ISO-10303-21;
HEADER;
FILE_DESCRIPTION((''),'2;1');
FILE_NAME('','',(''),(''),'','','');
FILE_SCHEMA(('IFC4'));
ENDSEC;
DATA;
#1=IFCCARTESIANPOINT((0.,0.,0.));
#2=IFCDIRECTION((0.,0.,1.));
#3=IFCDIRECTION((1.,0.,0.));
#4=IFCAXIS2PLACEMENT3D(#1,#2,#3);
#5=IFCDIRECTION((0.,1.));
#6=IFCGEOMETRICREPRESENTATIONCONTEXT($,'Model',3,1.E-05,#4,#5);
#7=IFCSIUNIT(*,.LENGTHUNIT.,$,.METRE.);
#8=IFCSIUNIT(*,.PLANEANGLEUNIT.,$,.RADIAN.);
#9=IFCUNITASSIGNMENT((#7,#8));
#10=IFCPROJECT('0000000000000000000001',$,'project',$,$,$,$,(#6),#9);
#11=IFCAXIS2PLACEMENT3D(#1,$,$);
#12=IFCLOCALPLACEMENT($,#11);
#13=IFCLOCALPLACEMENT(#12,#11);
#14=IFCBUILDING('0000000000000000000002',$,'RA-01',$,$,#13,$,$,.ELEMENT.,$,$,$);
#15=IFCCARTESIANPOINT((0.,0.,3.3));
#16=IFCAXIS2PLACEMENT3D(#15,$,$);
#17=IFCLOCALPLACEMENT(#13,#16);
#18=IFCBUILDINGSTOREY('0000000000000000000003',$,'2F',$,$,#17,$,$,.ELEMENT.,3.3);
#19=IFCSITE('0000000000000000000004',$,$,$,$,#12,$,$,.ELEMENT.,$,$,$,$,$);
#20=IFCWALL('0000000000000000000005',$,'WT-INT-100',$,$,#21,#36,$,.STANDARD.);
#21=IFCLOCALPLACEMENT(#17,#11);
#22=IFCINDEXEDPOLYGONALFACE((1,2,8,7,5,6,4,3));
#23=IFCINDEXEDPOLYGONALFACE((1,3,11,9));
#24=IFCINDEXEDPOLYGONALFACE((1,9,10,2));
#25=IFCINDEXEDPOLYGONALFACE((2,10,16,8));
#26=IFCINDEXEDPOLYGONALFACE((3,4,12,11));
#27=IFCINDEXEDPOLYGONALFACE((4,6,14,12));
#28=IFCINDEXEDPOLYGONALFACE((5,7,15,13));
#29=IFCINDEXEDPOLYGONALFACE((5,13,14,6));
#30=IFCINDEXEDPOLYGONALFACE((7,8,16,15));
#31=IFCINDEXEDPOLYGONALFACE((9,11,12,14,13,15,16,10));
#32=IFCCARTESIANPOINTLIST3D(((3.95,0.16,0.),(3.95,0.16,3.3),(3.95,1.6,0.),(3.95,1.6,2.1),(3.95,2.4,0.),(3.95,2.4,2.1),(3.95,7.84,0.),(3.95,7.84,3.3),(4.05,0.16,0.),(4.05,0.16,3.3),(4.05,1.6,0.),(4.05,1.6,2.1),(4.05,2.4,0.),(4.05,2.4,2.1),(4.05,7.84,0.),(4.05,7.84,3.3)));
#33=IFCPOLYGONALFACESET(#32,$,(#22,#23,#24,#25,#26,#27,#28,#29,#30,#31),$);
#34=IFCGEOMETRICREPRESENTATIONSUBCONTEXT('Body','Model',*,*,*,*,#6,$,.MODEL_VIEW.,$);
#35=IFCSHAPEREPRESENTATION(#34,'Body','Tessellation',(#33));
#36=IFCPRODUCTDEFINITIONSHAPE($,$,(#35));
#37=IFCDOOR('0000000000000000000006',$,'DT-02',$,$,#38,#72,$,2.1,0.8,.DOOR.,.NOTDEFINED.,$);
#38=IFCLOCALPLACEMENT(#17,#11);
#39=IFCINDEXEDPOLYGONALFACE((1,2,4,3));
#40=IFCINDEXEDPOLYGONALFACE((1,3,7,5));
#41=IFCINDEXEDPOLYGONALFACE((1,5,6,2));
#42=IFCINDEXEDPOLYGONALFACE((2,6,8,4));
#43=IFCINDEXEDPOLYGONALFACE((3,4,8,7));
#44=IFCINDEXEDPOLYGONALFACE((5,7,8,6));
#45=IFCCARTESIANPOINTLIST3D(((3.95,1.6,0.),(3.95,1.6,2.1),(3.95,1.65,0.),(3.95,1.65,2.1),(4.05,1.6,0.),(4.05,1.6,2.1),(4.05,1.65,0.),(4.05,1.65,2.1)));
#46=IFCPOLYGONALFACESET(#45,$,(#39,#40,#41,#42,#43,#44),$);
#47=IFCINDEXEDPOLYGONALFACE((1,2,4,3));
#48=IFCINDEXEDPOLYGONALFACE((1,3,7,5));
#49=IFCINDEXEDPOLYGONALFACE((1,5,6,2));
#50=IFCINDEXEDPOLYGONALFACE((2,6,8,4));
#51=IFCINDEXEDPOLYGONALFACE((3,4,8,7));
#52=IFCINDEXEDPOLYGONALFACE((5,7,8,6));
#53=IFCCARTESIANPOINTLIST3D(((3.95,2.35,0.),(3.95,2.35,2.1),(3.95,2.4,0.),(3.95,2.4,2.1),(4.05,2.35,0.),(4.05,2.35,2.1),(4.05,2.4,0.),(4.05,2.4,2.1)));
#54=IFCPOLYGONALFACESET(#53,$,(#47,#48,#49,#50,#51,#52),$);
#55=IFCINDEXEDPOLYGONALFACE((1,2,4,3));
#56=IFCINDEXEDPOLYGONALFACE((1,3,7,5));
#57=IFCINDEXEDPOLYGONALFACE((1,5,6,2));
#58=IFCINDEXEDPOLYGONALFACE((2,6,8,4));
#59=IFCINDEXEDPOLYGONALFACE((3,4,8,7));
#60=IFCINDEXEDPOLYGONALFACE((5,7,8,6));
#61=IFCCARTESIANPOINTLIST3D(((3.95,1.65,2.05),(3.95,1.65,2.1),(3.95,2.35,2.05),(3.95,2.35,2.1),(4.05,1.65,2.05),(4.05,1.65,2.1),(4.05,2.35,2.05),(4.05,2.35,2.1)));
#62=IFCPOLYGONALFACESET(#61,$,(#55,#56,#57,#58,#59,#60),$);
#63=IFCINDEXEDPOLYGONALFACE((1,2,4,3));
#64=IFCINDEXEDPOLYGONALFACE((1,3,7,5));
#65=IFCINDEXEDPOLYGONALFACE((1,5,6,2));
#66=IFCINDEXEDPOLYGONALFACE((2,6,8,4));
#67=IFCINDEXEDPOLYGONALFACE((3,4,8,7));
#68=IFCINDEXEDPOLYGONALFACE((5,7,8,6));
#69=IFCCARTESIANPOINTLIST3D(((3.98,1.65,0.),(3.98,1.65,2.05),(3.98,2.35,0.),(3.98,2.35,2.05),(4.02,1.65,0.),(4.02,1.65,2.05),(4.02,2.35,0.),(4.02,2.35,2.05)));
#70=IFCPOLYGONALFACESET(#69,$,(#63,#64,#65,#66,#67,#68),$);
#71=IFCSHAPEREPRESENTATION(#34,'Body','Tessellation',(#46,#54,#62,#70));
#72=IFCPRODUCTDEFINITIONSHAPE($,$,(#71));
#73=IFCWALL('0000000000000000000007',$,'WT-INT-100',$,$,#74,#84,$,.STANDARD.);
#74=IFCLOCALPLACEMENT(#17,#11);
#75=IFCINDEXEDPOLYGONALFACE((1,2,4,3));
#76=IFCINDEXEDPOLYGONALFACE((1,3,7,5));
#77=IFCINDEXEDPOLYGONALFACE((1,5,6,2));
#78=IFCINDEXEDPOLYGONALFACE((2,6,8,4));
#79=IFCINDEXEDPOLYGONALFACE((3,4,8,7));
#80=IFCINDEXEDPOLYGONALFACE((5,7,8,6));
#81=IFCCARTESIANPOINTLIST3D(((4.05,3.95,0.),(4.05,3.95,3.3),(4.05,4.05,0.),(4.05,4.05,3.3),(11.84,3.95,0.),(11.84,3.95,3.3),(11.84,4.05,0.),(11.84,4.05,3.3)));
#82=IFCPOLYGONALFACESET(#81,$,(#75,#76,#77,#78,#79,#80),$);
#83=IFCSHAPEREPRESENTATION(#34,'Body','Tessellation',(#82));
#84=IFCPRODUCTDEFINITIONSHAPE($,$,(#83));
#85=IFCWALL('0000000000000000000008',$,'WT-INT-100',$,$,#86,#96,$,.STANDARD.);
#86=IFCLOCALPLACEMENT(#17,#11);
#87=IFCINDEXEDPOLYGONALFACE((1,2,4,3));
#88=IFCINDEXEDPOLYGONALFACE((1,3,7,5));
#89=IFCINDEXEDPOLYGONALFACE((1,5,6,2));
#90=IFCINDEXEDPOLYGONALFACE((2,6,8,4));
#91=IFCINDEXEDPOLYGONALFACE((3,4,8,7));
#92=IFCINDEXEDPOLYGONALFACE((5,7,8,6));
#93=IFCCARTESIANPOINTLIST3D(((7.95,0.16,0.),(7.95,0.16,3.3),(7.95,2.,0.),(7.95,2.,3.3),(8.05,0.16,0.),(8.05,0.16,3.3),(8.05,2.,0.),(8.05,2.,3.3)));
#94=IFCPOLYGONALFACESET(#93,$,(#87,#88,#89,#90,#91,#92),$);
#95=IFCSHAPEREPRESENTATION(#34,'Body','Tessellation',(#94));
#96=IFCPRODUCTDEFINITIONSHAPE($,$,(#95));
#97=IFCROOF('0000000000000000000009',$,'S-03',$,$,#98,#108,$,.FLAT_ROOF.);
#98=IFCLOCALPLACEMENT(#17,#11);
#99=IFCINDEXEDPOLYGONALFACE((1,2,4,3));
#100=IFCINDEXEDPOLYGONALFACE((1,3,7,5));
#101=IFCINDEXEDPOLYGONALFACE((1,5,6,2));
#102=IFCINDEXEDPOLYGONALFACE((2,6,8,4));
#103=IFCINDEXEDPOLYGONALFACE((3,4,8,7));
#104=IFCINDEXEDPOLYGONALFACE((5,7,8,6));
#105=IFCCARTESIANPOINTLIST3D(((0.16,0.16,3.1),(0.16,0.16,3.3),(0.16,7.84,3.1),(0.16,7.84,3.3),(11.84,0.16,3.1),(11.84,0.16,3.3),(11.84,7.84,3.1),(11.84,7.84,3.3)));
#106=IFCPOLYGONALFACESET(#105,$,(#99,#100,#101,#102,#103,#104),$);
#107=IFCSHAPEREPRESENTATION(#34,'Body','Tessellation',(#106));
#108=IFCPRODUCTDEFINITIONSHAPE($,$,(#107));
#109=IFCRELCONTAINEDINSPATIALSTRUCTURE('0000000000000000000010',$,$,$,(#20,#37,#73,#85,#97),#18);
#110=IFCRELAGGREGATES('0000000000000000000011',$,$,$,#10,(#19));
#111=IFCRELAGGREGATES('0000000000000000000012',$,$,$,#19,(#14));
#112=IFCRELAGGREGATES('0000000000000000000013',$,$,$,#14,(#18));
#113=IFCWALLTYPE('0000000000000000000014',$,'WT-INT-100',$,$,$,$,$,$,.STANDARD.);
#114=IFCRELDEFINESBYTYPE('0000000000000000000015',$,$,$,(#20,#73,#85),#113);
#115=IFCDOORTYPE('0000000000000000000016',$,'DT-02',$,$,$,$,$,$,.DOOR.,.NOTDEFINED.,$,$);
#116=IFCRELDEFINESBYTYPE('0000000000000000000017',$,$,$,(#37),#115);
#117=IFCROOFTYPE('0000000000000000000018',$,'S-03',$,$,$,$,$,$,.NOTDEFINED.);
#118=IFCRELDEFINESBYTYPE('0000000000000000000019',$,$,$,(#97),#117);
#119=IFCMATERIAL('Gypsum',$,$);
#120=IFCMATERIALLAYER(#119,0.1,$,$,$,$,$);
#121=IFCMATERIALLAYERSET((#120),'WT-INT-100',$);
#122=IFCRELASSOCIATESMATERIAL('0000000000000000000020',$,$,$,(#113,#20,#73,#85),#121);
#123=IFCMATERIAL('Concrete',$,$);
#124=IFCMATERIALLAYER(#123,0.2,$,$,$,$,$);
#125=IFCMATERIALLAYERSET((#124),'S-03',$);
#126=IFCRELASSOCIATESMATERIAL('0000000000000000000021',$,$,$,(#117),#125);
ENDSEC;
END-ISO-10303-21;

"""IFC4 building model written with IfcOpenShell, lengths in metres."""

from ifc_helpers import new_model, si_unit, direction, frame, frame_2d, origin, origin_with_axes, place, context, subcontext, project, spatial, polyline, rectangle, outline, extrude, material, layer, layer_set, layer_usage, type_object, element, fill, save


model = new_model("IFC4")

# Units and contexts
model_context = context("Model", 3, precision=1e-05, world=origin_with_axes(), true_north=direction((0.0, 1.0)))
body_context = subcontext(model_context, "Body", "Model", "MODEL_VIEW")
ifc_project = project(units=[si_unit("LENGTHUNIT", "METRE"), si_unit("PLANEANGLEUNIT", "RADIAN")], contexts=[model_context])

# Site, building, storey
site_placement = place(None, origin())
site = spatial("IfcSite", under=ifc_project, at=site_placement, CompositionType="ELEMENT")
building_placement = place(site_placement, origin())
building = spatial("IfcBuilding", under=site, at=building_placement, Name="RA-01", CompositionType="ELEMENT")
storey_placement = place(building_placement, frame((0.0, 0.0, 3.3)))
storey = spatial("IfcBuildingStorey", under=building, at=storey_placement, Name="2F", CompositionType="ELEMENT", Elevation=3.3)

# Shared definitions
ifc_material_1 = material(Name="Concrete")

# Wall, opening, door
ifc_material_2 = material(Name="Gypsum")
ifc_layer_1 = layer(ifc_material_2, 0.1)
ifc_layer_set_1 = layer_set([ifc_layer_1], Name="WT-INT-100")
ifc_layer_usage_1 = layer_usage(ifc_layer_set_1, "AXIS2", "NEGATIVE", 0.05)
wall_type_1 = type_object("IfcWallType", Name="WT-INT-100", PredefinedType="STANDARD", material=ifc_layer_set_1)
wall_1_placement = place(storey_placement, frame((4.0, 0.16, 0.0), z_axis=(0.0, 0.0, 1.0), x_axis=(0.0, 1.0, 0.0)))
wall_1 = element("IfcWall", 1, at=wall_1_placement, inside=storey, type_object=wall_type_1, material=ifc_layer_usage_1, Name="WT-INT-100", PredefinedType="STANDARD", context=body_context, shape_type="SweptSolid", body=[
    extrude(outline(polyline([(0.0, -0.05), (7.68, -0.05), (7.68, 0.05), (0.0, 0.05), (0.0, -0.05)])), origin(), (0.0, 0.0, 1.0), 3.3),
])
opening_1_placement = place(wall_1_placement, frame((1.44, 0.0, 0.0)))
opening_1 = element("IfcOpeningElement", 2, at=opening_1_placement, cuts=wall_1, PredefinedType="OPENING", context=body_context, shape_type="SweptSolid", body=[
    extrude(rectangle(XDim=0.8, YDim=0.2, at=frame_2d((0.4, 0.0))), origin(), (0.0, 0.0, 1.0), 2.1),
])
door_type_1 = type_object("IfcDoorType", Name="DT-02", OperationType="NOTDEFINED", PredefinedType="DOOR")
door_1_placement = place(opening_1_placement, origin())
door_1 = element("IfcDoor", 3, at=door_1_placement, inside=storey, type_object=door_type_1, Name="DT-02", OperationType="NOTDEFINED", OverallHeight=2.1, OverallWidth=0.8, PredefinedType="DOOR", context=body_context, shape_type="SweptSolid", body=[
    extrude(outline(polyline([(0.0, -0.05), (0.05, -0.05), (0.05, 0.05), (0.0, 0.05), (0.0, -0.05)])), origin(), (0.0, 0.0, 1.0), 2.1),
    extrude(outline(polyline([(0.75, -0.05), (0.8, -0.05), (0.8, 0.05), (0.75, 0.05), (0.75, -0.05)])), origin(), (0.0, 0.0, 1.0), 2.1),
    extrude(outline(polyline([(0.05, -0.05), (0.75, -0.05), (0.75, 0.05), (0.05, 0.05), (0.05, -0.05)])), frame((0.0, 0.0, 2.05)), (0.0, 0.0, 1.0), 0.05),
    extrude(outline(polyline([(0.05, -0.02), (0.75, -0.02), (0.75, 0.02), (0.05, 0.02), (0.05, -0.02)])), origin(), (0.0, 0.0, 1.0), 2.05),
])
fill(opening_1, door_1)

# Walls
wall_2_placement = place(storey_placement, frame((4.05, 4.0, 0.0)))
element("IfcWall", 4, at=wall_2_placement, inside=storey, type_object=wall_type_1, material=ifc_layer_usage_1, Name="WT-INT-100", PredefinedType="STANDARD", context=body_context, shape_type="SweptSolid", body=[
    extrude(outline(polyline([(0.0, -0.05), (7.79, -0.05), (7.79, 0.05), (0.0, 0.05), (0.0, -0.05)])), origin(), (0.0, 0.0, 1.0), 3.3),
])
wall_3_placement = place(storey_placement, frame((8.0, 0.16, 0.0), z_axis=(0.0, 0.0, 1.0), x_axis=(0.0, 1.0, 0.0)))
element("IfcWall", 5, at=wall_3_placement, inside=storey, type_object=wall_type_1, material=ifc_layer_usage_1, Name="WT-INT-100", PredefinedType="STANDARD", context=body_context, shape_type="SweptSolid", body=[
    extrude(outline(polyline([(0.0, -0.05), (1.84, -0.05), (1.84, 0.05), (0.0, 0.05), (0.0, -0.05)])), origin(), (0.0, 0.0, 1.0), 3.3),
])

# Roof
ifc_layer_2 = layer(ifc_material_1, 0.2)
ifc_layer_set_2 = layer_set([ifc_layer_2], Name="S-03")
roof_type = type_object("IfcRoofType", Name="S-03", PredefinedType="NOTDEFINED", material=ifc_layer_set_2)
roof_placement = place(storey_placement, frame((0.0, 0.0, 3.1)))
element("IfcRoof", 6, at=roof_placement, inside=storey, type_object=roof_type, Name="S-03", PredefinedType="FLAT_ROOF", context=body_context, shape_type="SweptSolid", body=[
    extrude(outline(polyline([(0.16, 0.16), (11.84, 0.16), (11.84, 7.84), (0.16, 7.84), (0.16, 0.16)])), origin(), (0.0, 0.0, 1.0), 0.2),
])

save(model, "model.ifc")
